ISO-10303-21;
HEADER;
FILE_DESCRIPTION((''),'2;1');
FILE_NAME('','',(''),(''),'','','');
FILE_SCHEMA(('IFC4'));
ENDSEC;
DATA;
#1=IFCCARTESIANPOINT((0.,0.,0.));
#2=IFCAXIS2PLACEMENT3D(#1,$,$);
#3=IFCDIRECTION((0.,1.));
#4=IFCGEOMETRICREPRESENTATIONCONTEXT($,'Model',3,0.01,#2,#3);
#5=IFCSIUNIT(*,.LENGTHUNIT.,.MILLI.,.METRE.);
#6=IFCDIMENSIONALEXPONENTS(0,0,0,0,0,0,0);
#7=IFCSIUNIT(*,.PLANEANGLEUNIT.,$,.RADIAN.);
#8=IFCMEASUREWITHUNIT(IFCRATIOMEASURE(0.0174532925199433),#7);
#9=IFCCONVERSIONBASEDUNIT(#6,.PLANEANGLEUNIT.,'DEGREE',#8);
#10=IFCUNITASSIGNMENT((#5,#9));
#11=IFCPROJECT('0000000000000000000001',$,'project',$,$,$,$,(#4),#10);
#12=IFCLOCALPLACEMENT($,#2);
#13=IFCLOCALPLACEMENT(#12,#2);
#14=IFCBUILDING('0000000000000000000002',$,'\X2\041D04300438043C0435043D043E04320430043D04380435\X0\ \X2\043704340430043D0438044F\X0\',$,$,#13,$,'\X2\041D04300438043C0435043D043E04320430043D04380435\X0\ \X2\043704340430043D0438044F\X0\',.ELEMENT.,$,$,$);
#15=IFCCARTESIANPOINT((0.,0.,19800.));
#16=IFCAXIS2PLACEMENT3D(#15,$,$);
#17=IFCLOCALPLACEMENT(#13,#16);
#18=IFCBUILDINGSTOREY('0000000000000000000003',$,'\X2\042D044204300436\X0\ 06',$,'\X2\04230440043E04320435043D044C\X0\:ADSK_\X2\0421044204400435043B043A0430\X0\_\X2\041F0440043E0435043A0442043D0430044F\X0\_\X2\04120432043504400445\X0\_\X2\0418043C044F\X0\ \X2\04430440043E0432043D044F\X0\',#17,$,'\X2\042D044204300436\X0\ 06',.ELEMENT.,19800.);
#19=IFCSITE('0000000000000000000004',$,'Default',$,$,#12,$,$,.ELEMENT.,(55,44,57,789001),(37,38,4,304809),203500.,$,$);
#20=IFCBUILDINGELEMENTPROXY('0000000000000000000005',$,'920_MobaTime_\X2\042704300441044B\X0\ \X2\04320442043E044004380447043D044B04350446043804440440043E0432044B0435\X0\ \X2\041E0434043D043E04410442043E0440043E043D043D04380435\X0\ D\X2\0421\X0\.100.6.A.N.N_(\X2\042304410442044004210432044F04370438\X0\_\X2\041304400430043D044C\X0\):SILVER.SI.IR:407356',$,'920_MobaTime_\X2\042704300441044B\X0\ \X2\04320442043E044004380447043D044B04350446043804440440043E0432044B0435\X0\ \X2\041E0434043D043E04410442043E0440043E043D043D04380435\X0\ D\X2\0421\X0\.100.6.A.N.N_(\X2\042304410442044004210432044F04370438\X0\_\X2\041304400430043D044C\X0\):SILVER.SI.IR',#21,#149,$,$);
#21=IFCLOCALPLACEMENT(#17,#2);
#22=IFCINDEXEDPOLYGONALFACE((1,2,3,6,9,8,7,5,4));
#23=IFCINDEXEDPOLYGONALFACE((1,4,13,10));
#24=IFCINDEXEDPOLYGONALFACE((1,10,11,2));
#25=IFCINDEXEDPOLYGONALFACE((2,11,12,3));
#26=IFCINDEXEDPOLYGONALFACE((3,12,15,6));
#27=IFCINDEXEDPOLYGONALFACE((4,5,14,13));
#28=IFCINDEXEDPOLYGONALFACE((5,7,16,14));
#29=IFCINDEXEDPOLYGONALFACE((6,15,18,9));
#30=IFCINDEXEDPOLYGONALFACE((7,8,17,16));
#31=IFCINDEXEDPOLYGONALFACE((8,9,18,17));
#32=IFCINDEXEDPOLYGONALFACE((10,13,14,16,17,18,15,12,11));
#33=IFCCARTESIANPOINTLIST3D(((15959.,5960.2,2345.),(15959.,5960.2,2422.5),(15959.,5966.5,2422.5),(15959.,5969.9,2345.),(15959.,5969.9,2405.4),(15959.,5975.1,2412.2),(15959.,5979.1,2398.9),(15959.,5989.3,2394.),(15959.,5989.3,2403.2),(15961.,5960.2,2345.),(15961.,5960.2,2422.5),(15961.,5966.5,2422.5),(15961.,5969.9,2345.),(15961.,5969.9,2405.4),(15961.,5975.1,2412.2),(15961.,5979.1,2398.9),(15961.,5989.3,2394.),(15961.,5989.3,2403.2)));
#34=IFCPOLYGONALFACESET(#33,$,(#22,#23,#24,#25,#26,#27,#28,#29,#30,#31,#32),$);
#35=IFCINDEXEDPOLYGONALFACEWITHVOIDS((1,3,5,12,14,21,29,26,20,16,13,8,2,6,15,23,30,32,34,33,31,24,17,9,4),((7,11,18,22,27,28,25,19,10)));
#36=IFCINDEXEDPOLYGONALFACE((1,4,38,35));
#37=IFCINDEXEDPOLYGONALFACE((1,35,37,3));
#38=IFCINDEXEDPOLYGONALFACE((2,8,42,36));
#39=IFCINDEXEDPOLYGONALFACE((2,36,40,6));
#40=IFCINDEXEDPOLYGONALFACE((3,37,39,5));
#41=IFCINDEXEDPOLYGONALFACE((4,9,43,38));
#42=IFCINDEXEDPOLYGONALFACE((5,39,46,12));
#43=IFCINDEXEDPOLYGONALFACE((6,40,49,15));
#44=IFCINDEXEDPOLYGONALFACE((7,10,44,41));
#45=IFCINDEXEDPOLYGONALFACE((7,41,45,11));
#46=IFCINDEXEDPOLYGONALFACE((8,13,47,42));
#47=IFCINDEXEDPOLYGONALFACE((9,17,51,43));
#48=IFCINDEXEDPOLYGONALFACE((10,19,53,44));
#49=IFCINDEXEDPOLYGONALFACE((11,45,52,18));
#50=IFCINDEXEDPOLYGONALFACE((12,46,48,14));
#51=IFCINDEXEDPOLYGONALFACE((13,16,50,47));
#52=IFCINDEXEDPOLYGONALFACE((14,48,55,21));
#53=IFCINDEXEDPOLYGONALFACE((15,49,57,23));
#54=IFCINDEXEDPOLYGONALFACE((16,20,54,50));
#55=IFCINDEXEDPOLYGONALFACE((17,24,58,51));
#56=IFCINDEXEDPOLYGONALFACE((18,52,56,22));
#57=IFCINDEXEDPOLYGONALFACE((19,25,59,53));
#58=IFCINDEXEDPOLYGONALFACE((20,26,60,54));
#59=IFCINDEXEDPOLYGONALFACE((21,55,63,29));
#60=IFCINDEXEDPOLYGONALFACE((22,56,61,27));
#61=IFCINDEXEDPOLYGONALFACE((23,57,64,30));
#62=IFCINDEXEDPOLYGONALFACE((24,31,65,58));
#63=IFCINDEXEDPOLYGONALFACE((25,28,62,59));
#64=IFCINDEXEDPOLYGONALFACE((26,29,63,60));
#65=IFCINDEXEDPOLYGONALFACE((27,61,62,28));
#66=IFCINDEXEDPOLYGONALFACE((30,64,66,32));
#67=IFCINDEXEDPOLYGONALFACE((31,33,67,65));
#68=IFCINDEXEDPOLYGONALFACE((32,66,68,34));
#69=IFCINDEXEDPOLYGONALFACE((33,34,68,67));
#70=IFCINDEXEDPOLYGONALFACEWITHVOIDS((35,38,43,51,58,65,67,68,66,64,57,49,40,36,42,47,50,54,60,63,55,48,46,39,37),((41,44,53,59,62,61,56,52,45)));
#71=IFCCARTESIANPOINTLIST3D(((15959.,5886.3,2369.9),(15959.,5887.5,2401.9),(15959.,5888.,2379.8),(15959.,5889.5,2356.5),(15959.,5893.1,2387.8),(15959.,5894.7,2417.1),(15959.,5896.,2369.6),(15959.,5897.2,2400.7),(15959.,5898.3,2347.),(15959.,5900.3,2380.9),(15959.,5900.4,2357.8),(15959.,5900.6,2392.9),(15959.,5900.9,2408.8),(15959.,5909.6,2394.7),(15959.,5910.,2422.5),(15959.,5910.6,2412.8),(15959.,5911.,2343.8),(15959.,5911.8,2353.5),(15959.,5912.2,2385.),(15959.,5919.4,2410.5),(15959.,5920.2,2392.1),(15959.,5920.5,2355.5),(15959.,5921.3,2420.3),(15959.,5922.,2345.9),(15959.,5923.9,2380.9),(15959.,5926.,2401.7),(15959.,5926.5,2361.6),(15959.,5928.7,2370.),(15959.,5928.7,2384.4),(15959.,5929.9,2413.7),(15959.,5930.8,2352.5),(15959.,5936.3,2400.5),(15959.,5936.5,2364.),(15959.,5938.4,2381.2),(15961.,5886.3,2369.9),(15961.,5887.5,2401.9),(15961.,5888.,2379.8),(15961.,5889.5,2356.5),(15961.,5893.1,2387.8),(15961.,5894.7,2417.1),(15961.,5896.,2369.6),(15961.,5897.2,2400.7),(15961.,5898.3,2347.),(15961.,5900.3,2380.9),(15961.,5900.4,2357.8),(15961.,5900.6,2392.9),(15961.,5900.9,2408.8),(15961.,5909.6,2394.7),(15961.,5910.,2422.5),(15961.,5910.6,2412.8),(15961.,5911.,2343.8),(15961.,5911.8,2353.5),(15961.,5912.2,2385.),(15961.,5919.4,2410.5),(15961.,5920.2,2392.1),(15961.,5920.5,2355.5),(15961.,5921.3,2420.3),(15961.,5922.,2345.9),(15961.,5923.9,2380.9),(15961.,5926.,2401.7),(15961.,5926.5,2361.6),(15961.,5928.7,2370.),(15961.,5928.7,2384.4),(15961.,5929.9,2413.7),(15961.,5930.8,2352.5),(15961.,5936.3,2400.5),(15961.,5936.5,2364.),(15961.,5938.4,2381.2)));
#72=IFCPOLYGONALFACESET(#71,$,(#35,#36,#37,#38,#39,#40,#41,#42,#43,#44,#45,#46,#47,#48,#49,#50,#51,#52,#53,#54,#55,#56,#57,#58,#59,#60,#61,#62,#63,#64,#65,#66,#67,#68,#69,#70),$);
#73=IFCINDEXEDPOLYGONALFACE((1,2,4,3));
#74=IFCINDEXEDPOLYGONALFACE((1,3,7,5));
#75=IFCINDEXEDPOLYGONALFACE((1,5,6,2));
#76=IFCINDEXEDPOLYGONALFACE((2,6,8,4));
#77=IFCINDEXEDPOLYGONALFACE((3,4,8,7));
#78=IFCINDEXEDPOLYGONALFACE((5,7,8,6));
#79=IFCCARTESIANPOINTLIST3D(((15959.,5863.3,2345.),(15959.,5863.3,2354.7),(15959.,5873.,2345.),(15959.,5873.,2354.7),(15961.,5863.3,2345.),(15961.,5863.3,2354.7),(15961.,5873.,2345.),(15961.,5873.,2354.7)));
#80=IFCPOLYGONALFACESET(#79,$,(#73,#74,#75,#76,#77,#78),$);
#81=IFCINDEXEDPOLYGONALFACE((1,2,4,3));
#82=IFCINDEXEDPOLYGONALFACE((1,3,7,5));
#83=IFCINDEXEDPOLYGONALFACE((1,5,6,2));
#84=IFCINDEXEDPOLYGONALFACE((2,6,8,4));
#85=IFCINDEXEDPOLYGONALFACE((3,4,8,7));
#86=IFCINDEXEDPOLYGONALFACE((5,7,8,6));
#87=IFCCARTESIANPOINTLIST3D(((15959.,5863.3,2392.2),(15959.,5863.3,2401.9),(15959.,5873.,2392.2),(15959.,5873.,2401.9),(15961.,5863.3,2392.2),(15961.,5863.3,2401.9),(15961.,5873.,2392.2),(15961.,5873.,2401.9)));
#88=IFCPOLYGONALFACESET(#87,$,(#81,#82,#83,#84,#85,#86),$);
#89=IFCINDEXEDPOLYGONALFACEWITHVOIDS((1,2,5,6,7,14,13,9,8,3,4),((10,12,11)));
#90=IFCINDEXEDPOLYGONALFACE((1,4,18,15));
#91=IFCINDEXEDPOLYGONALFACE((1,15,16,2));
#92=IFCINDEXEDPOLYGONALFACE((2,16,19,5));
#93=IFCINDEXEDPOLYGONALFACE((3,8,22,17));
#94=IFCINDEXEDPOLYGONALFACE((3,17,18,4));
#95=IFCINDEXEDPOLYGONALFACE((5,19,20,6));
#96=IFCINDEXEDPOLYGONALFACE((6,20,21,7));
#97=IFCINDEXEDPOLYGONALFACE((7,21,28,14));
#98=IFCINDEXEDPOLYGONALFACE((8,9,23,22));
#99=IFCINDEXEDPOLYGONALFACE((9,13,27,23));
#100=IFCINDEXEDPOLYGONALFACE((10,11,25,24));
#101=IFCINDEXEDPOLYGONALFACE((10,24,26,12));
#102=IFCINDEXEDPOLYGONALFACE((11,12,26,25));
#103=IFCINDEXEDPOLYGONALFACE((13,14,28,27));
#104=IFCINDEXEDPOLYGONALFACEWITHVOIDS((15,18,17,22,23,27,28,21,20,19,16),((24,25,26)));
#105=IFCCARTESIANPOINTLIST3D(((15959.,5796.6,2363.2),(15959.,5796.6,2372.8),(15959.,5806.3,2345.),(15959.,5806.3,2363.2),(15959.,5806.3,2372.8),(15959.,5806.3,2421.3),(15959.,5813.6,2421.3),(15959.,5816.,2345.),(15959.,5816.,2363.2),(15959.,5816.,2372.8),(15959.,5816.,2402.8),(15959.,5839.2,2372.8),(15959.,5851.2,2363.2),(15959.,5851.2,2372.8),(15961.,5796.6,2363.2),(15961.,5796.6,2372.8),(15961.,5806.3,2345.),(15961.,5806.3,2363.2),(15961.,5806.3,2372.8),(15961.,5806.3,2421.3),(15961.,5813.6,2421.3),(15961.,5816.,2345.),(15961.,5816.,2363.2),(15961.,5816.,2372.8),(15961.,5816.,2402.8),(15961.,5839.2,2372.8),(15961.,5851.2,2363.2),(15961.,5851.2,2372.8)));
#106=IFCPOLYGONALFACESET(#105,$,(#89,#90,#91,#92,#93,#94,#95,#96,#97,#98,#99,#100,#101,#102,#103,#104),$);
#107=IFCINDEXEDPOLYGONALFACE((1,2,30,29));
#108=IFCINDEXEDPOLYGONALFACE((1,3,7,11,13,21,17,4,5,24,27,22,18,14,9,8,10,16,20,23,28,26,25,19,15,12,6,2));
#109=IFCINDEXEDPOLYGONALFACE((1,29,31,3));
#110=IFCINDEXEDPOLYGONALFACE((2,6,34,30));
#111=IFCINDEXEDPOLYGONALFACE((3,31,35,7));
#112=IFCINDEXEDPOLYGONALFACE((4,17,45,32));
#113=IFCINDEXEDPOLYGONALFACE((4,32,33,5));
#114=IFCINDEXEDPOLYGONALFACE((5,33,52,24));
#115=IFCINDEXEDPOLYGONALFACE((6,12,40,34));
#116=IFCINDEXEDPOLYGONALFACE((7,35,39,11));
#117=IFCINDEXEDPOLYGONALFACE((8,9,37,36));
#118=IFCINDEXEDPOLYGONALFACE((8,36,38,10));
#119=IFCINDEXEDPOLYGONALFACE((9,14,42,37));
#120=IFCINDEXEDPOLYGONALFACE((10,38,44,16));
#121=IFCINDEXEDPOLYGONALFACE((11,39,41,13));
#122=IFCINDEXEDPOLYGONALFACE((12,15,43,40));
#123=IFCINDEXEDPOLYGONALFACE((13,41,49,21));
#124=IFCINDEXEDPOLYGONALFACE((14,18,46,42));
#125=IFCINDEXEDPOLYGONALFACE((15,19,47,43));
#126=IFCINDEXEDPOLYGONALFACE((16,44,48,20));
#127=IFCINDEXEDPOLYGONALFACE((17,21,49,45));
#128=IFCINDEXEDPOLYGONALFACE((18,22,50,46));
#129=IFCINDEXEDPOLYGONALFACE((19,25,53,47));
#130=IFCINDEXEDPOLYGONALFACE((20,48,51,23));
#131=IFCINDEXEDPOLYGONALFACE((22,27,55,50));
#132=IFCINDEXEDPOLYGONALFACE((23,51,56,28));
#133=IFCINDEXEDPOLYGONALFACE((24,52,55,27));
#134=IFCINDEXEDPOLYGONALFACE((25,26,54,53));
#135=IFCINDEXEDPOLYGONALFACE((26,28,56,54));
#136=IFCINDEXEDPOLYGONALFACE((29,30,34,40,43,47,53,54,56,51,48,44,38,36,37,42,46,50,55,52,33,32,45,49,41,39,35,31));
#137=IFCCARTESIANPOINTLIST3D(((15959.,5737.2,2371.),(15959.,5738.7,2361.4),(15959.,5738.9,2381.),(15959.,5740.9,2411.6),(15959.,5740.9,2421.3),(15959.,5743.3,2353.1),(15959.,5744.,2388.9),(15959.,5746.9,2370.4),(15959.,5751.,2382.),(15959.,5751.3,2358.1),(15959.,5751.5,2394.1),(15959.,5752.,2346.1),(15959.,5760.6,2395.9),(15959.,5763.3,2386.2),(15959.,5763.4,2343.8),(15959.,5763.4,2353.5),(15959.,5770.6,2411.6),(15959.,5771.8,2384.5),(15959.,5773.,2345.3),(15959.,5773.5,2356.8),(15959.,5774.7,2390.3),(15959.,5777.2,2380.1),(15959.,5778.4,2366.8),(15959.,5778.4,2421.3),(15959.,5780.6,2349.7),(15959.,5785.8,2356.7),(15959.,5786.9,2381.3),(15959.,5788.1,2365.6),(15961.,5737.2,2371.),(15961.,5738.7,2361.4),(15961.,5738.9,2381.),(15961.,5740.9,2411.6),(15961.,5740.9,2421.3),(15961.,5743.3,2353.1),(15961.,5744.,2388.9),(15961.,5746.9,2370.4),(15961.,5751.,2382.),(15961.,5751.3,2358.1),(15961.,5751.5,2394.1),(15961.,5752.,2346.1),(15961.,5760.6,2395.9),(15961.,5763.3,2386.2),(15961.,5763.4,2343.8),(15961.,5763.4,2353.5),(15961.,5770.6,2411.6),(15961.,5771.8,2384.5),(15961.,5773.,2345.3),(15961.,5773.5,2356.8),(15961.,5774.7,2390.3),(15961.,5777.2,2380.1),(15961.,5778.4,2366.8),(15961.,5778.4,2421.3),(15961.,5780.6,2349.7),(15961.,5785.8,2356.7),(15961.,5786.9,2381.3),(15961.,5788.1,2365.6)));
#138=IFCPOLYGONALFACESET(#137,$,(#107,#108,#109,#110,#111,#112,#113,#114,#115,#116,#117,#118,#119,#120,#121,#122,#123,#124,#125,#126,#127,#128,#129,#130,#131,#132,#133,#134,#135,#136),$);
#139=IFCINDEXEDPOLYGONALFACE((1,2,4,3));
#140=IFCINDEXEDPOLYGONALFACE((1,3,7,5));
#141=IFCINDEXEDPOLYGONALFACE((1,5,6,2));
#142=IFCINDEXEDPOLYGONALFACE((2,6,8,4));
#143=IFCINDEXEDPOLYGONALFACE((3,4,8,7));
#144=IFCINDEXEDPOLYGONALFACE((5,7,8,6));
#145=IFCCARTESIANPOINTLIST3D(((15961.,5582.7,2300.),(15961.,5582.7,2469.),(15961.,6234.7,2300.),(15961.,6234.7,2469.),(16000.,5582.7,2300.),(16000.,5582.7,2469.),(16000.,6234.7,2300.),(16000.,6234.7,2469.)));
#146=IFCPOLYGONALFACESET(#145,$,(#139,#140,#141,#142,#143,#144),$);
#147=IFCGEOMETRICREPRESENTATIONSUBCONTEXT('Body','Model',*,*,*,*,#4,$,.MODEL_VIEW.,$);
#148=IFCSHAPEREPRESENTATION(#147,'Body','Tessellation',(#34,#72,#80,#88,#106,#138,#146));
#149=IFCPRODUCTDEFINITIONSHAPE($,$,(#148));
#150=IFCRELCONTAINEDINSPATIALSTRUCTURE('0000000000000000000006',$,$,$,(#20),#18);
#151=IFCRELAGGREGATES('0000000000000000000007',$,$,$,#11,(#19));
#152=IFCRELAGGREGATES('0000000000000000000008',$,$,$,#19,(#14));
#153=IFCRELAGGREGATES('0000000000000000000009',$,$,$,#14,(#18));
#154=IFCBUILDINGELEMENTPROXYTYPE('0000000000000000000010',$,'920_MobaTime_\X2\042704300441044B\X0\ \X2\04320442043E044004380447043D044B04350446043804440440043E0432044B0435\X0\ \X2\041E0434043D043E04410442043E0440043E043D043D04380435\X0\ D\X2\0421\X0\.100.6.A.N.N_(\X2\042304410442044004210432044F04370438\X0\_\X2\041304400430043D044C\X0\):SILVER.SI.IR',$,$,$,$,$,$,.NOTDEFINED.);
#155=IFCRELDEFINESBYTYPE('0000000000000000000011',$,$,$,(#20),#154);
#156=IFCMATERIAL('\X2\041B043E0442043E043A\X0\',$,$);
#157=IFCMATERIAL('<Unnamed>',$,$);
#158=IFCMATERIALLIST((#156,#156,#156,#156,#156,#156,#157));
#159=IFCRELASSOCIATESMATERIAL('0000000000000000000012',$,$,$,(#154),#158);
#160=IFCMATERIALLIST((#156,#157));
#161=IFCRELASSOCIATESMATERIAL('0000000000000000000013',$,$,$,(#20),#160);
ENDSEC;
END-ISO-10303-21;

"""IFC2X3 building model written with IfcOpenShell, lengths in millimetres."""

from ifc_helpers import new_model, entity, si_unit, converted_unit, direction, frame, origin, origin_2d_with_axis, place, context, subcontext, project, spatial, polyline, rectangle, outline, extrude, source, transform, mapped, material, material_list, type_object, type_shapes, element, save


model = new_model("IFC2X3")

# Units and contexts
model_context = context("Model", 3, precision=0.01, world=origin(), true_north=direction((0.0, 1.0)))
body_context = subcontext(model_context, "Body", "Model", "MODEL_VIEW")
ifc_project = project(units=[si_unit("LENGTHUNIT", "METRE", prefix="MILLI"), converted_unit("PLANEANGLEUNIT", "DEGREE", entity("IfcRatioMeasure", 0.0174532925199433), si_unit("PLANEANGLEUNIT", "RADIAN"), dimensions=[0, 0, 0, 0, 0, 0, 0])], contexts=[model_context])

# Site, building, storey
site_placement = place(None, frame((0.0, 0.0, 0.0)))
site = spatial("IfcSite", under=ifc_project, at=site_placement, Name="Default", CompositionType="ELEMENT", RefLatitude=(55, 44, 57, 789001), RefLongitude=(37, 38, 4, 304809), RefElevation=203500.0)
building_placement = place(site_placement, origin())
building = spatial("IfcBuilding", under=site, at=building_placement, Name="Наименование здания", LongName="Наименование здания", CompositionType="ELEMENT")
storey_placement = place(building_placement, frame((0.0, 0.0, 19800.0)))
storey = spatial("IfcBuildingStorey", under=building, at=storey_placement, Name="Этаж 06", ObjectType="Уровень:ADSK_Стрелка_Проектная_Вверх_Имя уровня", LongName="Этаж 06", CompositionType="ELEMENT", Elevation=19800.0)

# Building element proxy
ifc_material_1 = material(Name="Лоток")
ifc_material_2 = material(Name="<Unnamed>")
ifc_material_list_1 = material_list([ifc_material_1, ifc_material_1, ifc_material_1, ifc_material_1, ifc_material_1, ifc_material_1, ifc_material_2])
building_element_proxy_type_1 = type_object("IfcBuildingElementProxyType", Name="920_MobaTime_Часы вторичныецифровые Односторонние DС.100.6.A.N.N_(УстрСвязи_Грань):SILVER.SI.IR", PredefinedType="NOTDEFINED", material=ifc_material_list_1)
shared_shape_1 = source(origin(), body_context, "Body", "SweptSolid", [
    extrude(outline(polyline([(-49.3, -13.1), (28.2, -13.1), (28.2, -6.8), (17.9, 1.8), (8.9, 16.0), (-0.3, 16.0), (4.6, 5.8), (11.1, -3.4), (-49.3, -3.4), (-49.3, -13.1)])), frame((-64.6, 9.8, 39.0), z_axis=(0.0, 0.0, 1.0), x_axis=(0.0, 1.0, 0.0)), (0.0, 0.0, 1.0), 2.0),
    extrude(outline(polyline([(2.2, -27.6), (19.0, -27.6), (30.5, -16.1), (33.3, -4.9), (31.0, 5.8), (21.8, 17.2), (5.2, 27.3), (-11.1, 33.0), (-24.0, 32.7), (-33.6, 27.6), (-40.3, 18.6), (-42.8, 5.7), (-38.0, -6.3), (-27.2, -15.0), (-17.5, -17.7), (-8.2, -16.4), (-0.3, -11.9), (5.1, -4.5), (7.3, 6.2), (4.0, 17.2), (18.5, 7.3), (23.6, -2.4), (22.0, -11.4), (14.2, -18.4), (5.3, -18.3), (2.2, -27.6)]), holes=[polyline([(-9.0, 23.3), (-1.3, 14.4), (-2.6, 2.0), (-11.4, -7.0), (-23.4, -6.1), (-32.2, 2.9), (-31.2, 15.1), (-25.6, 22.1), (-17.5, 24.9), (-9.0, 23.3)])]), frame((-2.7, 3.6, 39.0), z_axis=(0.0, 0.0, 1.0), x_axis=(-0.427649, 0.903945, 0.0)), (0.0, 0.0, 1.0), 2.0),
    extrude(rectangle(XDim=9.7, YDim=9.7, at=origin_2d_with_axis()), frame((40.6, -34.7, 39.0)), (0.0, 0.0, 1.0), 2.0),
    extrude(rectangle(XDim=9.7, YDim=9.7, at=origin_2d_with_axis()), frame((40.6, 12.6, 39.0)), (0.0, 0.0, 1.0), 2.0),
    extrude(outline(polyline([(-0.9, -28.1), (8.8, -28.1), (8.8, -9.9), (18.5, -9.9), (18.5, -0.2), (8.8, -0.2), (8.8, 48.3), (1.5, 48.3), (-36.0, -0.2), (-36.0, -9.9), (-0.9, -9.9), (-0.9, -28.1)]), holes=[polyline([(-0.9, -0.2), (-24.1, -0.2), (-0.9, 29.7), (-0.9, -0.2)])]), frame((93.6, -11.4, 39.0)), (0.0, 0.0, 1.0), 2.0),
    extrude(outline(polyline([(3.3, -28.3), (12.5, -28.3), (20.5, -25.0), (26.8, -18.8), (30.7, -10.0), (31.4, 1.6), (26.9, 11.8), (20.1, 18.4), (11.1, 22.3), (1.0, 23.3), (-7.9, 20.4), (-14.9, 14.5), (-18.9, 6.2), (-17.1, -9.0), (-36.7, 0.5), (-29.1, 29.3), (-38.5, 31.7), (-48.1, -4.6), (-11.6, -23.0), (-8.0, -14.0), (-10.8, -7.6), (-10.2, 1.1), (-3.0, 11.8), (9.2, 12.8), (20.0, 5.4), (21.3, -7.5), (15.5, -16.4), (4.6, -18.6), (3.3, -28.3)])), frame((147.1, -8.5, 39.0), z_axis=(0.0, 0.0, 1.0), x_axis=(0.256974, -0.966418, 0.0)), (0.0, 0.0, 1.0), 2.0),
    extrude(rectangle(XDim=652.0, YDim=169.0, at=origin_2d_with_axis()), frame((0.0, 0.0, 0.0), z_axis=(0.0, 0.0, 1.0), x_axis=(-1.0, 0.0, 0.0)), (0.0, 0.0, 1.0), 39.0),
])
type_shapes(building_element_proxy_type_1, [shared_shape_1])
ifc_material_list_2 = material_list([ifc_material_1, ifc_material_2])
proxy_1_placement = place(storey_placement, frame((16000.0, 5908.7, 2384.5), z_axis=(-1.0, 0.0, 0.0), x_axis=(0.0, -1.0, 0.0)))
element("IfcBuildingElementProxy", 1, at=proxy_1_placement, inside=storey, type_object=building_element_proxy_type_1, material=ifc_material_list_2, Name="920_MobaTime_Часы вторичныецифровые Односторонние DС.100.6.A.N.N_(УстрСвязи_Грань):SILVER.SI.IR:407356", ObjectType="920_MobaTime_Часы вторичныецифровые Односторонние DС.100.6.A.N.N_(УстрСвязи_Грань):SILVER.SI.IR", context=body_context, shape_type="MappedRepresentation", body=[
    mapped(shared_shape_1, transform((0.0, 0.0, 0.0), scale=1.0)),
])

save(model, "model.ifc")
